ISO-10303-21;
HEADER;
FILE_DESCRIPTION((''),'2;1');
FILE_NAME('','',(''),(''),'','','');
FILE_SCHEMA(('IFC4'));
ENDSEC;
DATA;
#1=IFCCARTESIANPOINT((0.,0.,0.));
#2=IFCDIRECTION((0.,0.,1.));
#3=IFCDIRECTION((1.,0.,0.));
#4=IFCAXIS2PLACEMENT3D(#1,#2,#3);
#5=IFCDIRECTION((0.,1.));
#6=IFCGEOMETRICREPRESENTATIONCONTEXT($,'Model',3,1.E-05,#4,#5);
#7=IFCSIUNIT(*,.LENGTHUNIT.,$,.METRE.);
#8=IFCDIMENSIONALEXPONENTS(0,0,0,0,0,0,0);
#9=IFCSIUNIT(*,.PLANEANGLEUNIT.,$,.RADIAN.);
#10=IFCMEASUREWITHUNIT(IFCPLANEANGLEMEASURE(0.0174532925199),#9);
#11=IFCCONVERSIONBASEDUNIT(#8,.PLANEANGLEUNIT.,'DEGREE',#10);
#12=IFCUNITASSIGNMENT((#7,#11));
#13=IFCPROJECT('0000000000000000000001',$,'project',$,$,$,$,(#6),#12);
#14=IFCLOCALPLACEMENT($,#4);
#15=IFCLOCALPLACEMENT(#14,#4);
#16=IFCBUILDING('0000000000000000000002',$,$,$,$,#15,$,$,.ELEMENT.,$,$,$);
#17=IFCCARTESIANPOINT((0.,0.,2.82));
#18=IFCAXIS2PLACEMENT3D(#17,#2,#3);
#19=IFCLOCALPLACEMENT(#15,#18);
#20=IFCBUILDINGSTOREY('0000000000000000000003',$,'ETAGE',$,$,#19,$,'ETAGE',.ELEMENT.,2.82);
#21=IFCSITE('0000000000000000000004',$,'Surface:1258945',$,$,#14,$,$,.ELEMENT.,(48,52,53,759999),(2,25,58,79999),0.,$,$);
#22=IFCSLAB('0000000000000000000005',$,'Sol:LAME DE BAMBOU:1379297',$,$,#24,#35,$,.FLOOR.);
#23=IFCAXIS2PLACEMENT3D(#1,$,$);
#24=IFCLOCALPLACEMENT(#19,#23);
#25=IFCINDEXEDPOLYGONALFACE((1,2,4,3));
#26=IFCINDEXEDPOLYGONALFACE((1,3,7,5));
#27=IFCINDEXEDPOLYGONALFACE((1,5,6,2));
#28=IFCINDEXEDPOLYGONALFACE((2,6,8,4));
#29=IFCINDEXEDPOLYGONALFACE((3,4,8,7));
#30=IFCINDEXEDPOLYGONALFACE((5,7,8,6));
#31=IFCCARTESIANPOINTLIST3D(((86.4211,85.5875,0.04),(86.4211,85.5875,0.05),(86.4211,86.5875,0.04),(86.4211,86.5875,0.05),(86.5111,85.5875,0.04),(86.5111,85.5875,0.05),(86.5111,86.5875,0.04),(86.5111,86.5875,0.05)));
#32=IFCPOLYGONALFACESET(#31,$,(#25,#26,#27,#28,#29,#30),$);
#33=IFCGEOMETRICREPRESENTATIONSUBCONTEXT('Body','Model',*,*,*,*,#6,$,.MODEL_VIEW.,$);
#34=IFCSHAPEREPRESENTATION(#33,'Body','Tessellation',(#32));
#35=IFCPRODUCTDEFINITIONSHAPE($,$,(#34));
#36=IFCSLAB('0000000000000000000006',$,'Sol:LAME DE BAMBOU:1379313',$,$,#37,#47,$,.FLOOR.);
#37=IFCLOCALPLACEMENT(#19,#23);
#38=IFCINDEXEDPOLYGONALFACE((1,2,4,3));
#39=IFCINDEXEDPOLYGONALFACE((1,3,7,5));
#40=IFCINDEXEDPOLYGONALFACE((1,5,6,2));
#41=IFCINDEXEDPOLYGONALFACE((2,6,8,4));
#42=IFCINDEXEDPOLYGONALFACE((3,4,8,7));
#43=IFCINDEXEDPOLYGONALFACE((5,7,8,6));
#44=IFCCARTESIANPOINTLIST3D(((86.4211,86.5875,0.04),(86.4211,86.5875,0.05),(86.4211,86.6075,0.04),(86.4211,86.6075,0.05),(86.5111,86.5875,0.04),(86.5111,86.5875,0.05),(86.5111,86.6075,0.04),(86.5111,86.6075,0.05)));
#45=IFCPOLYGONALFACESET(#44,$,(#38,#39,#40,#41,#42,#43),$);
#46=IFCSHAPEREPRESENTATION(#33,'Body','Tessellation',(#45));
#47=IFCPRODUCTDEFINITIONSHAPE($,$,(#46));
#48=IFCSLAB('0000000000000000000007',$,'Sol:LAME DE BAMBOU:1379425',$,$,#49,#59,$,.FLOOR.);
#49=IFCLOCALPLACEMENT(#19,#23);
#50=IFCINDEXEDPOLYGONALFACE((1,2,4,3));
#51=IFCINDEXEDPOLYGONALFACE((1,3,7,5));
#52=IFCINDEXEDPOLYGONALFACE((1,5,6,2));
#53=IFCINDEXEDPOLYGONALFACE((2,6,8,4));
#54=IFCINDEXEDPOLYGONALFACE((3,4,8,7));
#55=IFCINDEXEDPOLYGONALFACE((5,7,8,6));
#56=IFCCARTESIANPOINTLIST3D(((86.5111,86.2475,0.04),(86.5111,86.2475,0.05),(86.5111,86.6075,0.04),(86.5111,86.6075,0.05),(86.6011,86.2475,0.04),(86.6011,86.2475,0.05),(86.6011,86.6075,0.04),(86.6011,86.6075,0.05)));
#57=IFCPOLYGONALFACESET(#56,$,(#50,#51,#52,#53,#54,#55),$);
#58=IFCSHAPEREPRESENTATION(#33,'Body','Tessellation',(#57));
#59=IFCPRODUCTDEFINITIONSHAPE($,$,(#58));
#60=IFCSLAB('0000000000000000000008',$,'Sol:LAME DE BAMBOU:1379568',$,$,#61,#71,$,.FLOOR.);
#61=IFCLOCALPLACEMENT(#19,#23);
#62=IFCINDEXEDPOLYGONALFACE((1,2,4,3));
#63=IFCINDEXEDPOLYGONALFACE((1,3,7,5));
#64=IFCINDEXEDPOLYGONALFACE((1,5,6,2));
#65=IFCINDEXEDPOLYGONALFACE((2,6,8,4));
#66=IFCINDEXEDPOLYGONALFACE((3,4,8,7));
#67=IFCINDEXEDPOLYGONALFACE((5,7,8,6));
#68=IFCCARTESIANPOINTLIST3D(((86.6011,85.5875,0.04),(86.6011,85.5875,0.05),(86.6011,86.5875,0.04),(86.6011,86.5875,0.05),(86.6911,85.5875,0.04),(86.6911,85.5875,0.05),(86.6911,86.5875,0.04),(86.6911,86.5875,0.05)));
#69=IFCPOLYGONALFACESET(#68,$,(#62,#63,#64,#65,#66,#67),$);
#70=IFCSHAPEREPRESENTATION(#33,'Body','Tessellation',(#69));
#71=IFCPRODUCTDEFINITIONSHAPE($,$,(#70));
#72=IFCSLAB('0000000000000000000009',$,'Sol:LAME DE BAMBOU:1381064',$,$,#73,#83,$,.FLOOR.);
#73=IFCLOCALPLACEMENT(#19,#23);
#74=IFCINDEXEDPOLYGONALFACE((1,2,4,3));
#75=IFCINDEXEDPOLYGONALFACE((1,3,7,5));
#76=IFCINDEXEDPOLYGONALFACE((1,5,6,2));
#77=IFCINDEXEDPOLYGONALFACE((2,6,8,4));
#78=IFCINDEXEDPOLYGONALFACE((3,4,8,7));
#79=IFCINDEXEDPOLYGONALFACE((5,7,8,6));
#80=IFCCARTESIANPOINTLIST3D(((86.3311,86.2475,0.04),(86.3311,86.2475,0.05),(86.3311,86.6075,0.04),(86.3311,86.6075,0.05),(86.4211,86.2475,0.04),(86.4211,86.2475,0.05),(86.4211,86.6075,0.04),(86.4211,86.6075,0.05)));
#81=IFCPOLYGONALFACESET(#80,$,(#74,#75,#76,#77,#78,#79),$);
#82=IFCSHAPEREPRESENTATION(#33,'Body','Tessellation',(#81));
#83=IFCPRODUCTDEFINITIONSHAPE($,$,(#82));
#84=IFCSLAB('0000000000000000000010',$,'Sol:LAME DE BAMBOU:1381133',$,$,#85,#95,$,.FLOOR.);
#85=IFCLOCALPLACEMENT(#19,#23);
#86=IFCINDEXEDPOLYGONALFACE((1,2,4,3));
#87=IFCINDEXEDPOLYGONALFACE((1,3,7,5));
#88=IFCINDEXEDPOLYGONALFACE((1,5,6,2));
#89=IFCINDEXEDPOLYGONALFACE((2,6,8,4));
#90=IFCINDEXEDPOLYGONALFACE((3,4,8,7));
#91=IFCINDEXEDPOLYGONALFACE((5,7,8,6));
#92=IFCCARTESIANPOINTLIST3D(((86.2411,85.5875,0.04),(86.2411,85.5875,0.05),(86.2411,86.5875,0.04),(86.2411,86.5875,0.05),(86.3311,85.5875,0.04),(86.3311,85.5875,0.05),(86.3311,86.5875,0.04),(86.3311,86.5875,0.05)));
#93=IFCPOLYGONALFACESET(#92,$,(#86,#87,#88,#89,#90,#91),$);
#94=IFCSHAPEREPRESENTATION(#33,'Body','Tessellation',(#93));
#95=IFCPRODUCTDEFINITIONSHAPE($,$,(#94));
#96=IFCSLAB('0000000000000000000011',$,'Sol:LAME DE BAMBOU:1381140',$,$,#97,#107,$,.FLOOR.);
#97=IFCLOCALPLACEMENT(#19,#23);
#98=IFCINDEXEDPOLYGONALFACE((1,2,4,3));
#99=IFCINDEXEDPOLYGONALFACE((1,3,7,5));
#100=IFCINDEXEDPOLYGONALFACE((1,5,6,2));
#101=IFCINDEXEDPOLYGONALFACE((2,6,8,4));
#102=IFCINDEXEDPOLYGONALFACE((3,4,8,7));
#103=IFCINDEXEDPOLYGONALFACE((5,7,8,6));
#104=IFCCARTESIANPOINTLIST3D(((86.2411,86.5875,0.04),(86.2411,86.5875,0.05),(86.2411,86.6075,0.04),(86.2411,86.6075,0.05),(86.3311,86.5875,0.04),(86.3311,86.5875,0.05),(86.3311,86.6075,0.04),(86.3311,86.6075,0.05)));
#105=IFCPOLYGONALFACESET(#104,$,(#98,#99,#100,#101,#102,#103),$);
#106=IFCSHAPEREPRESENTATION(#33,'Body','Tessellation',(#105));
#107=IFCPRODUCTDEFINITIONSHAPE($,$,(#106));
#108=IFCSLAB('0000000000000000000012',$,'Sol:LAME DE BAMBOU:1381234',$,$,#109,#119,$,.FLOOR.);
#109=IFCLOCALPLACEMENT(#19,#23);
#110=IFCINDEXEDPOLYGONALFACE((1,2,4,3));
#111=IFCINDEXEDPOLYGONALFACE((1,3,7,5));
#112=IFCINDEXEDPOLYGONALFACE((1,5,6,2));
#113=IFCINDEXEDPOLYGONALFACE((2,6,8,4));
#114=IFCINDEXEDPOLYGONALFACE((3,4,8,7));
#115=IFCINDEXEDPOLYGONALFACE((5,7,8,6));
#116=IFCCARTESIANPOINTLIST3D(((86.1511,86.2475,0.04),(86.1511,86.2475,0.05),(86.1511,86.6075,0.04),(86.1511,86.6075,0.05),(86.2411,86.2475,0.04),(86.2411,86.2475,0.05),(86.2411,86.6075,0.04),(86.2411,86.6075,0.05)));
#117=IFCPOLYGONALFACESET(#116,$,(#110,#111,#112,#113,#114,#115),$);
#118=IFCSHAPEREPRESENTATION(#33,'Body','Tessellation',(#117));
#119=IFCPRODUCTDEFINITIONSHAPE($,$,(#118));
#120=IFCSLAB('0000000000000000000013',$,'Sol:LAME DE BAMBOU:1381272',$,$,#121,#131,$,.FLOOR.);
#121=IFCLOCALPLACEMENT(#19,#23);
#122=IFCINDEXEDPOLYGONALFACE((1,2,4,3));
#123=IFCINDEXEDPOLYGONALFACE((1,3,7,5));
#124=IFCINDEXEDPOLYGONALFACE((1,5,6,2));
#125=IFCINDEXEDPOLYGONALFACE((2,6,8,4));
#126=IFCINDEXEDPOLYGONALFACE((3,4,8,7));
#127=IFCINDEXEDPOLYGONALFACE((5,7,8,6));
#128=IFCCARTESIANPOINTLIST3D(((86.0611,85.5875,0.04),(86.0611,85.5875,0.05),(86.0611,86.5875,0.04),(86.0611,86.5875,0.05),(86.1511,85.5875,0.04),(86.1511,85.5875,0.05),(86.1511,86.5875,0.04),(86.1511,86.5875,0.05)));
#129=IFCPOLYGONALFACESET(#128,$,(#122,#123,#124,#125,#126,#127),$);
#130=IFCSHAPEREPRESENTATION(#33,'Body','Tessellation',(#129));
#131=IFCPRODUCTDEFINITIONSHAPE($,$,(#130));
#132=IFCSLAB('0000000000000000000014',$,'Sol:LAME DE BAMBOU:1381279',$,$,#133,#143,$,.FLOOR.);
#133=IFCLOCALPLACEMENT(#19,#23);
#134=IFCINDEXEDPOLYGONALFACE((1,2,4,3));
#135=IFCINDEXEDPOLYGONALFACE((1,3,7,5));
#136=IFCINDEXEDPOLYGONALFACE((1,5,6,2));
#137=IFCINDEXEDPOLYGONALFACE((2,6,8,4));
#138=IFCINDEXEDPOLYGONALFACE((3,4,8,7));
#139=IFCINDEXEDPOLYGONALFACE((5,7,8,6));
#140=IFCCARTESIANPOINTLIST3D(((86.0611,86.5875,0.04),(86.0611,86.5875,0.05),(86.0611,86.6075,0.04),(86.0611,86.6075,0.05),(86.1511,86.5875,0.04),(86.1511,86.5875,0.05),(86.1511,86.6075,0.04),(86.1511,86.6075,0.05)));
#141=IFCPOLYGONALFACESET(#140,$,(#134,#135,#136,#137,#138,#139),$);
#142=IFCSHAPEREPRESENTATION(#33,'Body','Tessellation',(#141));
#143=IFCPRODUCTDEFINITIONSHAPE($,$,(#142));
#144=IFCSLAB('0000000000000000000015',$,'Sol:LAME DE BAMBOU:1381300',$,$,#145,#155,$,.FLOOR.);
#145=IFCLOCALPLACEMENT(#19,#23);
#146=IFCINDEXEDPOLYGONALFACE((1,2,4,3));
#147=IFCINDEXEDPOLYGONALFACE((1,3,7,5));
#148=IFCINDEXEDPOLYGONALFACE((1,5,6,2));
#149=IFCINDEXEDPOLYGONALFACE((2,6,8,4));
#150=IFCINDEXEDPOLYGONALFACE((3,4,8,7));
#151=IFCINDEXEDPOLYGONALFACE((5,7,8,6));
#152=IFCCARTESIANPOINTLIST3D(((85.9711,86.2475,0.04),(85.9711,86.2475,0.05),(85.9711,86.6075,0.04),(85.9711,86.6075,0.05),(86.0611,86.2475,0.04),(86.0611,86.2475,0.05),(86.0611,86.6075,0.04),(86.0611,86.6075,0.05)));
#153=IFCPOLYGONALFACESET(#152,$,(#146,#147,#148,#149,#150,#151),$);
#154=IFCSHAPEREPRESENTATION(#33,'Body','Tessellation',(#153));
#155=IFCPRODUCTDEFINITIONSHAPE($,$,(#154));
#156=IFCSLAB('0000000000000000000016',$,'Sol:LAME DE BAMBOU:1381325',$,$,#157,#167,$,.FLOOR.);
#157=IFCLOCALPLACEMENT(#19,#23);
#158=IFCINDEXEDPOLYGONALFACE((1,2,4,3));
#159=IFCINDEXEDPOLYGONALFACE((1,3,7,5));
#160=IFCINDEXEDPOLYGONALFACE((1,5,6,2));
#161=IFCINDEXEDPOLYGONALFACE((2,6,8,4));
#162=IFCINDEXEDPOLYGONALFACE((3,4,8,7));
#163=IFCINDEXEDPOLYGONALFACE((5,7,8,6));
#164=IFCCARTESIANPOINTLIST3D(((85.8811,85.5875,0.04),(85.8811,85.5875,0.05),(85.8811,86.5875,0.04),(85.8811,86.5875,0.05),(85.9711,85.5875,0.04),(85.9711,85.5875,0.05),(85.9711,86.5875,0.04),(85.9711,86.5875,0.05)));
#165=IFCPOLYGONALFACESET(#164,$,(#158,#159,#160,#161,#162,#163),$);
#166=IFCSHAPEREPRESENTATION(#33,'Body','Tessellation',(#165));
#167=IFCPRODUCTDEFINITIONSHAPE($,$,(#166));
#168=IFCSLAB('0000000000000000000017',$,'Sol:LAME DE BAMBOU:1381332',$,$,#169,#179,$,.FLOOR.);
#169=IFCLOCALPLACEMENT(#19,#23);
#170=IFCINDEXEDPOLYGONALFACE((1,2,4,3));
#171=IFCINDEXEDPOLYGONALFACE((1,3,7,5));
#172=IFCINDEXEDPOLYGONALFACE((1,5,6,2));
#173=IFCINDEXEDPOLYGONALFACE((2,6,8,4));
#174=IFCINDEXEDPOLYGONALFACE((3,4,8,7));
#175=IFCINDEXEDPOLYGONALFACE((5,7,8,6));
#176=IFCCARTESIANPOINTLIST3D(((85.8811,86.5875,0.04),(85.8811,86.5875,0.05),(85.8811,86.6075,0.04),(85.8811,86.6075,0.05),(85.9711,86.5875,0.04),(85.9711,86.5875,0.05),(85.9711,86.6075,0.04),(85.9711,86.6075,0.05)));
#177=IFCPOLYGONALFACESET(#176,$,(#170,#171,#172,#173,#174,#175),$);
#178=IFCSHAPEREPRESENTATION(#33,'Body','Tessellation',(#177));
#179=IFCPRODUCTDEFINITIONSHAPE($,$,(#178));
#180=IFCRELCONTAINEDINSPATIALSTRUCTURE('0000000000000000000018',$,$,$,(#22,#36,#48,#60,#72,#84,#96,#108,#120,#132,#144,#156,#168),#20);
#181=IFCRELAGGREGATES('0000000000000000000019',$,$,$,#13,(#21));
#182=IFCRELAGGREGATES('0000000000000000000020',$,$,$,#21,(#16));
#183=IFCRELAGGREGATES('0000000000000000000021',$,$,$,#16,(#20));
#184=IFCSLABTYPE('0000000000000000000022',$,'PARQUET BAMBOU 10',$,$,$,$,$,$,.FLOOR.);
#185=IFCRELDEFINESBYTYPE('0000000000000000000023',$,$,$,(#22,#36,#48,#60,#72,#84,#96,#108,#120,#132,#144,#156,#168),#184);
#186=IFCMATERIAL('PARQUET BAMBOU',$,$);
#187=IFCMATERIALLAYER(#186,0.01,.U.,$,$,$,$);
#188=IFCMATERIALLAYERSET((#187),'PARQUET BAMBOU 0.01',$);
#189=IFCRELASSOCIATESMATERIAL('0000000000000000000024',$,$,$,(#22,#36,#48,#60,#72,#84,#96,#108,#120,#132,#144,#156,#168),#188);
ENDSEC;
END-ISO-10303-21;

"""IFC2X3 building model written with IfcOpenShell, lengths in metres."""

from ifc_helpers import new_model, entity, si_unit, converted_unit, direction, frame, origin_with_axes, place, context, subcontext, project, spatial, polyline, outline, extrude, material, layer, layer_set, layer_usage, type_object, element, save


model = new_model("IFC2X3")

# Units and contexts
model_context = context("Model", 3, precision=1e-05, world=origin_with_axes(), true_north=direction((0.0, 1.0)))
body_context = subcontext(model_context, "Body", "Model", "MODEL_VIEW")
ifc_project = project(units=[si_unit("LENGTHUNIT", "METRE"), converted_unit("PLANEANGLEUNIT", "DEGREE", entity("IfcPlaneAngleMeasure", 0.0174532925199), si_unit("PLANEANGLEUNIT", "RADIAN"), dimensions=[0, 0, 0, 0, 0, 0, 0])], contexts=[model_context])

# Site, building, storey
site_placement = place(None, origin_with_axes())
site = spatial("IfcSite", under=ifc_project, at=site_placement, Name="Surface:1258945", CompositionType="ELEMENT", RefLatitude=(48, 52, 53, 759999), RefLongitude=(2, 25, 58, 79999), RefElevation=0.0)
building_placement = place(site_placement, origin_with_axes())
building = spatial("IfcBuilding", under=site, at=building_placement, CompositionType="ELEMENT")
storey_placement = place(building_placement, frame((0.0, 0.0, 2.82), z_axis=(0.0, 0.0, 1.0), x_axis=(1.0, 0.0, 0.0)))
storey = spatial("IfcBuildingStorey", under=building, at=storey_placement, Name="ETAGE", LongName="ETAGE", CompositionType="ELEMENT", Elevation=2.82)

# Slabs
ifc_material_1 = material(Name="PARQUET BAMBOU")
ifc_layer_1 = layer(ifc_material_1, 0.01, ventilated="UNKNOWN")
ifc_layer_set_1 = layer_set([ifc_layer_1], Name="PARQUET BAMBOU 0.01")
ifc_layer_usage_1 = layer_usage(ifc_layer_set_1, "AXIS3", "NEGATIVE", 0.01)
slab_type = type_object("IfcSlabType", Name="PARQUET BAMBOU 10", PredefinedType="FLOOR")
slab_1_placement = place(storey_placement, frame((86.4211, 86.5875, 0.05), z_axis=(0.0, 0.0, 1.0), x_axis=(1.0, 0.0, 0.0)))
element("IfcSlab", 1, at=slab_1_placement, inside=storey, type_object=slab_type, material=ifc_layer_usage_1, Name="Sol:LAME DE BAMBOU:1379297", PredefinedType="FLOOR", context=body_context, shape_type="SweptSolid", body=[
    extrude(outline(polyline([(0.0, 0.0), (0.0, -1.0), (0.09, -1.0), (0.09, 0.0), (0.0, 0.0)])), frame((0.0, 0.0, -0.01), z_axis=(0.0, 0.0, 1.0), x_axis=(1.0, 0.0, 0.0)), (0.0, 0.0, 1.0), 0.01),
])
ifc_layer_usage_2 = layer_usage(ifc_layer_set_1, "AXIS3", "NEGATIVE", 0.01)
slab_2_placement = place(storey_placement, frame((86.4211, 86.6075, 0.05), z_axis=(0.0, 0.0, 1.0), x_axis=(1.0, 0.0, 0.0)))
element("IfcSlab", 2, at=slab_2_placement, inside=storey, type_object=slab_type, material=ifc_layer_usage_2, Name="Sol:LAME DE BAMBOU:1379313", PredefinedType="FLOOR", context=body_context, shape_type="SweptSolid", body=[
    extrude(outline(polyline([(0.0, 0.0), (0.0, -0.02), (0.09, -0.02), (0.09, 0.0), (0.0, 0.0)])), frame((0.0, 0.0, -0.01), z_axis=(0.0, 0.0, 1.0), x_axis=(1.0, 0.0, 0.0)), (0.0, 0.0, 1.0), 0.01),
])
ifc_layer_usage_3 = layer_usage(ifc_layer_set_1, "AXIS3", "NEGATIVE", 0.01)
slab_3_placement = place(storey_placement, frame((86.5111, 86.6075, 0.05), z_axis=(0.0, 0.0, 1.0), x_axis=(1.0, 0.0, 0.0)))
element("IfcSlab", 3, at=slab_3_placement, inside=storey, type_object=slab_type, material=ifc_layer_usage_3, Name="Sol:LAME DE BAMBOU:1379425", PredefinedType="FLOOR", context=body_context, shape_type="SweptSolid", body=[
    extrude(outline(polyline([(0.0, 0.0), (0.0, -0.36), (0.09, -0.36), (0.09, 0.0), (0.0, 0.0)])), frame((0.0, 0.0, -0.01), z_axis=(0.0, 0.0, 1.0), x_axis=(1.0, 0.0, 0.0)), (0.0, 0.0, 1.0), 0.01),
])
ifc_layer_usage_4 = layer_usage(ifc_layer_set_1, "AXIS3", "NEGATIVE", 0.01)
slab_4_placement = place(storey_placement, frame((86.6011, 86.5875, 0.05), z_axis=(0.0, 0.0, 1.0), x_axis=(1.0, 0.0, 0.0)))
element("IfcSlab", 4, at=slab_4_placement, inside=storey, type_object=slab_type, material=ifc_layer_usage_4, Name="Sol:LAME DE BAMBOU:1379568", PredefinedType="FLOOR", context=body_context, shape_type="SweptSolid", body=[
    extrude(outline(polyline([(0.0, 0.0), (0.0, -1.0), (0.09, -1.0), (0.09, 0.0), (0.0, 0.0)])), frame((0.0, 0.0, -0.01), z_axis=(0.0, 0.0, 1.0), x_axis=(1.0, 0.0, 0.0)), (0.0, 0.0, 1.0), 0.01),
])
ifc_layer_usage_5 = layer_usage(ifc_layer_set_1, "AXIS3", "NEGATIVE", 0.01)
slab_5_placement = place(storey_placement, frame((86.3311, 86.6075, 0.05), z_axis=(0.0, 0.0, 1.0), x_axis=(1.0, 0.0, 0.0)))
element("IfcSlab", 5, at=slab_5_placement, inside=storey, type_object=slab_type, material=ifc_layer_usage_5, Name="Sol:LAME DE BAMBOU:1381064", PredefinedType="FLOOR", context=body_context, shape_type="SweptSolid", body=[
    extrude(outline(polyline([(0.0, 0.0), (0.0, -0.36), (0.09, -0.36), (0.09, 0.0), (0.0, 0.0)])), frame((0.0, 0.0, -0.01), z_axis=(0.0, 0.0, 1.0), x_axis=(1.0, 0.0, 0.0)), (0.0, 0.0, 1.0), 0.01),
])
ifc_layer_usage_6 = layer_usage(ifc_layer_set_1, "AXIS3", "NEGATIVE", 0.01)
slab_6_placement = place(storey_placement, frame((86.2411, 86.5875, 0.05), z_axis=(0.0, 0.0, 1.0), x_axis=(1.0, 0.0, 0.0)))
element("IfcSlab", 6, at=slab_6_placement, inside=storey, type_object=slab_type, material=ifc_layer_usage_6, Name="Sol:LAME DE BAMBOU:1381133", PredefinedType="FLOOR", context=body_context, shape_type="SweptSolid", body=[
    extrude(outline(polyline([(0.0, 0.0), (0.0, -1.0), (0.09, -1.0), (0.09, 0.0), (0.0, 0.0)])), frame((0.0, 0.0, -0.01), z_axis=(0.0, 0.0, 1.0), x_axis=(1.0, 0.0, 0.0)), (0.0, 0.0, 1.0), 0.01),
])
ifc_layer_usage_7 = layer_usage(ifc_layer_set_1, "AXIS3", "NEGATIVE", 0.01)
slab_7_placement = place(storey_placement, frame((86.2411, 86.6075, 0.05), z_axis=(0.0, 0.0, 1.0), x_axis=(1.0, 0.0, 0.0)))
element("IfcSlab", 7, at=slab_7_placement, inside=storey, type_object=slab_type, material=ifc_layer_usage_7, Name="Sol:LAME DE BAMBOU:1381140", PredefinedType="FLOOR", context=body_context, shape_type="SweptSolid", body=[
    extrude(outline(polyline([(0.0, 0.0), (0.0, -0.02), (0.09, -0.02), (0.09, 0.0), (0.0, 0.0)])), frame((0.0, 0.0, -0.01), z_axis=(0.0, 0.0, 1.0), x_axis=(1.0, 0.0, 0.0)), (0.0, 0.0, 1.0), 0.01),
])
ifc_layer_usage_8 = layer_usage(ifc_layer_set_1, "AXIS3", "NEGATIVE", 0.01)
slab_8_placement = place(storey_placement, frame((86.1511, 86.6075, 0.05), z_axis=(0.0, 0.0, 1.0), x_axis=(1.0, 0.0, 0.0)))
element("IfcSlab", 8, at=slab_8_placement, inside=storey, type_object=slab_type, material=ifc_layer_usage_8, Name="Sol:LAME DE BAMBOU:1381234", PredefinedType="FLOOR", context=body_context, shape_type="SweptSolid", body=[
    extrude(outline(polyline([(0.0, 0.0), (0.0, -0.36), (0.09, -0.36), (0.09, 0.0), (0.0, 0.0)])), frame((0.0, 0.0, -0.01), z_axis=(0.0, 0.0, 1.0), x_axis=(1.0, 0.0, 0.0)), (0.0, 0.0, 1.0), 0.01),
])
ifc_layer_usage_9 = layer_usage(ifc_layer_set_1, "AXIS3", "NEGATIVE", 0.01)
slab_9_placement = place(storey_placement, frame((86.0611, 86.5875, 0.05), z_axis=(0.0, 0.0, 1.0), x_axis=(1.0, 0.0, 0.0)))
element("IfcSlab", 9, at=slab_9_placement, inside=storey, type_object=slab_type, material=ifc_layer_usage_9, Name="Sol:LAME DE BAMBOU:1381272", PredefinedType="FLOOR", context=body_context, shape_type="SweptSolid", body=[
    extrude(outline(polyline([(0.0, 0.0), (0.0, -1.0), (0.09, -1.0), (0.09, 0.0), (0.0, 0.0)])), frame((0.0, 0.0, -0.01), z_axis=(0.0, 0.0, 1.0), x_axis=(1.0, 0.0, 0.0)), (0.0, 0.0, 1.0), 0.01),
])
ifc_layer_usage_10 = layer_usage(ifc_layer_set_1, "AXIS3", "NEGATIVE", 0.01)
slab_10_placement = place(storey_placement, frame((86.0611, 86.6075, 0.05), z_axis=(0.0, 0.0, 1.0), x_axis=(1.0, 0.0, 0.0)))
element("IfcSlab", 10, at=slab_10_placement, inside=storey, type_object=slab_type, material=ifc_layer_usage_10, Name="Sol:LAME DE BAMBOU:1381279", PredefinedType="FLOOR", context=body_context, shape_type="SweptSolid", body=[
    extrude(outline(polyline([(0.0, 0.0), (0.0, -0.02), (0.09, -0.02), (0.09, 0.0), (0.0, 0.0)])), frame((0.0, 0.0, -0.01), z_axis=(0.0, 0.0, 1.0), x_axis=(1.0, 0.0, 0.0)), (0.0, 0.0, 1.0), 0.01),
])
ifc_layer_usage_11 = layer_usage(ifc_layer_set_1, "AXIS3", "NEGATIVE", 0.01)
slab_11_placement = place(storey_placement, frame((85.9711, 86.6075, 0.05), z_axis=(0.0, 0.0, 1.0), x_axis=(1.0, 0.0, 0.0)))
element("IfcSlab", 11, at=slab_11_placement, inside=storey, type_object=slab_type, material=ifc_layer_usage_11, Name="Sol:LAME DE BAMBOU:1381300", PredefinedType="FLOOR", context=body_context, shape_type="SweptSolid", body=[
    extrude(outline(polyline([(0.0, 0.0), (0.0, -0.36), (0.09, -0.36), (0.09, 0.0), (0.0, 0.0)])), frame((0.0, 0.0, -0.01), z_axis=(0.0, 0.0, 1.0), x_axis=(1.0, 0.0, 0.0)), (0.0, 0.0, 1.0), 0.01),
])
ifc_layer_usage_12 = layer_usage(ifc_layer_set_1, "AXIS3", "NEGATIVE", 0.01)
slab_12_placement = place(storey_placement, frame((85.8811, 86.5875, 0.05), z_axis=(0.0, 0.0, 1.0), x_axis=(1.0, 0.0, 0.0)))
element("IfcSlab", 12, at=slab_12_placement, inside=storey, type_object=slab_type, material=ifc_layer_usage_12, Name="Sol:LAME DE BAMBOU:1381325", PredefinedType="FLOOR", context=body_context, shape_type="SweptSolid", body=[
    extrude(outline(polyline([(0.0, 0.0), (0.0, -1.0), (0.09, -1.0), (0.09, 0.0), (0.0, 0.0)])), frame((0.0, 0.0, -0.01), z_axis=(0.0, 0.0, 1.0), x_axis=(1.0, 0.0, 0.0)), (0.0, 0.0, 1.0), 0.01),
])
ifc_layer_usage_13 = layer_usage(ifc_layer_set_1, "AXIS3", "NEGATIVE", 0.01)
slab_13_placement = place(storey_placement, frame((85.8811, 86.6075, 0.05), z_axis=(0.0, 0.0, 1.0), x_axis=(1.0, 0.0, 0.0)))
element("IfcSlab", 13, at=slab_13_placement, inside=storey, type_object=slab_type, material=ifc_layer_usage_13, Name="Sol:LAME DE BAMBOU:1381332", PredefinedType="FLOOR", context=body_context, shape_type="SweptSolid", body=[
    extrude(outline(polyline([(0.0, 0.0), (0.0, -0.02), (0.09, -0.02), (0.09, 0.0), (0.0, 0.0)])), frame((0.0, 0.0, -0.01), z_axis=(0.0, 0.0, 1.0), x_axis=(1.0, 0.0, 0.0)), (0.0, 0.0, 1.0), 0.01),
])

save(model, "model.ifc")
